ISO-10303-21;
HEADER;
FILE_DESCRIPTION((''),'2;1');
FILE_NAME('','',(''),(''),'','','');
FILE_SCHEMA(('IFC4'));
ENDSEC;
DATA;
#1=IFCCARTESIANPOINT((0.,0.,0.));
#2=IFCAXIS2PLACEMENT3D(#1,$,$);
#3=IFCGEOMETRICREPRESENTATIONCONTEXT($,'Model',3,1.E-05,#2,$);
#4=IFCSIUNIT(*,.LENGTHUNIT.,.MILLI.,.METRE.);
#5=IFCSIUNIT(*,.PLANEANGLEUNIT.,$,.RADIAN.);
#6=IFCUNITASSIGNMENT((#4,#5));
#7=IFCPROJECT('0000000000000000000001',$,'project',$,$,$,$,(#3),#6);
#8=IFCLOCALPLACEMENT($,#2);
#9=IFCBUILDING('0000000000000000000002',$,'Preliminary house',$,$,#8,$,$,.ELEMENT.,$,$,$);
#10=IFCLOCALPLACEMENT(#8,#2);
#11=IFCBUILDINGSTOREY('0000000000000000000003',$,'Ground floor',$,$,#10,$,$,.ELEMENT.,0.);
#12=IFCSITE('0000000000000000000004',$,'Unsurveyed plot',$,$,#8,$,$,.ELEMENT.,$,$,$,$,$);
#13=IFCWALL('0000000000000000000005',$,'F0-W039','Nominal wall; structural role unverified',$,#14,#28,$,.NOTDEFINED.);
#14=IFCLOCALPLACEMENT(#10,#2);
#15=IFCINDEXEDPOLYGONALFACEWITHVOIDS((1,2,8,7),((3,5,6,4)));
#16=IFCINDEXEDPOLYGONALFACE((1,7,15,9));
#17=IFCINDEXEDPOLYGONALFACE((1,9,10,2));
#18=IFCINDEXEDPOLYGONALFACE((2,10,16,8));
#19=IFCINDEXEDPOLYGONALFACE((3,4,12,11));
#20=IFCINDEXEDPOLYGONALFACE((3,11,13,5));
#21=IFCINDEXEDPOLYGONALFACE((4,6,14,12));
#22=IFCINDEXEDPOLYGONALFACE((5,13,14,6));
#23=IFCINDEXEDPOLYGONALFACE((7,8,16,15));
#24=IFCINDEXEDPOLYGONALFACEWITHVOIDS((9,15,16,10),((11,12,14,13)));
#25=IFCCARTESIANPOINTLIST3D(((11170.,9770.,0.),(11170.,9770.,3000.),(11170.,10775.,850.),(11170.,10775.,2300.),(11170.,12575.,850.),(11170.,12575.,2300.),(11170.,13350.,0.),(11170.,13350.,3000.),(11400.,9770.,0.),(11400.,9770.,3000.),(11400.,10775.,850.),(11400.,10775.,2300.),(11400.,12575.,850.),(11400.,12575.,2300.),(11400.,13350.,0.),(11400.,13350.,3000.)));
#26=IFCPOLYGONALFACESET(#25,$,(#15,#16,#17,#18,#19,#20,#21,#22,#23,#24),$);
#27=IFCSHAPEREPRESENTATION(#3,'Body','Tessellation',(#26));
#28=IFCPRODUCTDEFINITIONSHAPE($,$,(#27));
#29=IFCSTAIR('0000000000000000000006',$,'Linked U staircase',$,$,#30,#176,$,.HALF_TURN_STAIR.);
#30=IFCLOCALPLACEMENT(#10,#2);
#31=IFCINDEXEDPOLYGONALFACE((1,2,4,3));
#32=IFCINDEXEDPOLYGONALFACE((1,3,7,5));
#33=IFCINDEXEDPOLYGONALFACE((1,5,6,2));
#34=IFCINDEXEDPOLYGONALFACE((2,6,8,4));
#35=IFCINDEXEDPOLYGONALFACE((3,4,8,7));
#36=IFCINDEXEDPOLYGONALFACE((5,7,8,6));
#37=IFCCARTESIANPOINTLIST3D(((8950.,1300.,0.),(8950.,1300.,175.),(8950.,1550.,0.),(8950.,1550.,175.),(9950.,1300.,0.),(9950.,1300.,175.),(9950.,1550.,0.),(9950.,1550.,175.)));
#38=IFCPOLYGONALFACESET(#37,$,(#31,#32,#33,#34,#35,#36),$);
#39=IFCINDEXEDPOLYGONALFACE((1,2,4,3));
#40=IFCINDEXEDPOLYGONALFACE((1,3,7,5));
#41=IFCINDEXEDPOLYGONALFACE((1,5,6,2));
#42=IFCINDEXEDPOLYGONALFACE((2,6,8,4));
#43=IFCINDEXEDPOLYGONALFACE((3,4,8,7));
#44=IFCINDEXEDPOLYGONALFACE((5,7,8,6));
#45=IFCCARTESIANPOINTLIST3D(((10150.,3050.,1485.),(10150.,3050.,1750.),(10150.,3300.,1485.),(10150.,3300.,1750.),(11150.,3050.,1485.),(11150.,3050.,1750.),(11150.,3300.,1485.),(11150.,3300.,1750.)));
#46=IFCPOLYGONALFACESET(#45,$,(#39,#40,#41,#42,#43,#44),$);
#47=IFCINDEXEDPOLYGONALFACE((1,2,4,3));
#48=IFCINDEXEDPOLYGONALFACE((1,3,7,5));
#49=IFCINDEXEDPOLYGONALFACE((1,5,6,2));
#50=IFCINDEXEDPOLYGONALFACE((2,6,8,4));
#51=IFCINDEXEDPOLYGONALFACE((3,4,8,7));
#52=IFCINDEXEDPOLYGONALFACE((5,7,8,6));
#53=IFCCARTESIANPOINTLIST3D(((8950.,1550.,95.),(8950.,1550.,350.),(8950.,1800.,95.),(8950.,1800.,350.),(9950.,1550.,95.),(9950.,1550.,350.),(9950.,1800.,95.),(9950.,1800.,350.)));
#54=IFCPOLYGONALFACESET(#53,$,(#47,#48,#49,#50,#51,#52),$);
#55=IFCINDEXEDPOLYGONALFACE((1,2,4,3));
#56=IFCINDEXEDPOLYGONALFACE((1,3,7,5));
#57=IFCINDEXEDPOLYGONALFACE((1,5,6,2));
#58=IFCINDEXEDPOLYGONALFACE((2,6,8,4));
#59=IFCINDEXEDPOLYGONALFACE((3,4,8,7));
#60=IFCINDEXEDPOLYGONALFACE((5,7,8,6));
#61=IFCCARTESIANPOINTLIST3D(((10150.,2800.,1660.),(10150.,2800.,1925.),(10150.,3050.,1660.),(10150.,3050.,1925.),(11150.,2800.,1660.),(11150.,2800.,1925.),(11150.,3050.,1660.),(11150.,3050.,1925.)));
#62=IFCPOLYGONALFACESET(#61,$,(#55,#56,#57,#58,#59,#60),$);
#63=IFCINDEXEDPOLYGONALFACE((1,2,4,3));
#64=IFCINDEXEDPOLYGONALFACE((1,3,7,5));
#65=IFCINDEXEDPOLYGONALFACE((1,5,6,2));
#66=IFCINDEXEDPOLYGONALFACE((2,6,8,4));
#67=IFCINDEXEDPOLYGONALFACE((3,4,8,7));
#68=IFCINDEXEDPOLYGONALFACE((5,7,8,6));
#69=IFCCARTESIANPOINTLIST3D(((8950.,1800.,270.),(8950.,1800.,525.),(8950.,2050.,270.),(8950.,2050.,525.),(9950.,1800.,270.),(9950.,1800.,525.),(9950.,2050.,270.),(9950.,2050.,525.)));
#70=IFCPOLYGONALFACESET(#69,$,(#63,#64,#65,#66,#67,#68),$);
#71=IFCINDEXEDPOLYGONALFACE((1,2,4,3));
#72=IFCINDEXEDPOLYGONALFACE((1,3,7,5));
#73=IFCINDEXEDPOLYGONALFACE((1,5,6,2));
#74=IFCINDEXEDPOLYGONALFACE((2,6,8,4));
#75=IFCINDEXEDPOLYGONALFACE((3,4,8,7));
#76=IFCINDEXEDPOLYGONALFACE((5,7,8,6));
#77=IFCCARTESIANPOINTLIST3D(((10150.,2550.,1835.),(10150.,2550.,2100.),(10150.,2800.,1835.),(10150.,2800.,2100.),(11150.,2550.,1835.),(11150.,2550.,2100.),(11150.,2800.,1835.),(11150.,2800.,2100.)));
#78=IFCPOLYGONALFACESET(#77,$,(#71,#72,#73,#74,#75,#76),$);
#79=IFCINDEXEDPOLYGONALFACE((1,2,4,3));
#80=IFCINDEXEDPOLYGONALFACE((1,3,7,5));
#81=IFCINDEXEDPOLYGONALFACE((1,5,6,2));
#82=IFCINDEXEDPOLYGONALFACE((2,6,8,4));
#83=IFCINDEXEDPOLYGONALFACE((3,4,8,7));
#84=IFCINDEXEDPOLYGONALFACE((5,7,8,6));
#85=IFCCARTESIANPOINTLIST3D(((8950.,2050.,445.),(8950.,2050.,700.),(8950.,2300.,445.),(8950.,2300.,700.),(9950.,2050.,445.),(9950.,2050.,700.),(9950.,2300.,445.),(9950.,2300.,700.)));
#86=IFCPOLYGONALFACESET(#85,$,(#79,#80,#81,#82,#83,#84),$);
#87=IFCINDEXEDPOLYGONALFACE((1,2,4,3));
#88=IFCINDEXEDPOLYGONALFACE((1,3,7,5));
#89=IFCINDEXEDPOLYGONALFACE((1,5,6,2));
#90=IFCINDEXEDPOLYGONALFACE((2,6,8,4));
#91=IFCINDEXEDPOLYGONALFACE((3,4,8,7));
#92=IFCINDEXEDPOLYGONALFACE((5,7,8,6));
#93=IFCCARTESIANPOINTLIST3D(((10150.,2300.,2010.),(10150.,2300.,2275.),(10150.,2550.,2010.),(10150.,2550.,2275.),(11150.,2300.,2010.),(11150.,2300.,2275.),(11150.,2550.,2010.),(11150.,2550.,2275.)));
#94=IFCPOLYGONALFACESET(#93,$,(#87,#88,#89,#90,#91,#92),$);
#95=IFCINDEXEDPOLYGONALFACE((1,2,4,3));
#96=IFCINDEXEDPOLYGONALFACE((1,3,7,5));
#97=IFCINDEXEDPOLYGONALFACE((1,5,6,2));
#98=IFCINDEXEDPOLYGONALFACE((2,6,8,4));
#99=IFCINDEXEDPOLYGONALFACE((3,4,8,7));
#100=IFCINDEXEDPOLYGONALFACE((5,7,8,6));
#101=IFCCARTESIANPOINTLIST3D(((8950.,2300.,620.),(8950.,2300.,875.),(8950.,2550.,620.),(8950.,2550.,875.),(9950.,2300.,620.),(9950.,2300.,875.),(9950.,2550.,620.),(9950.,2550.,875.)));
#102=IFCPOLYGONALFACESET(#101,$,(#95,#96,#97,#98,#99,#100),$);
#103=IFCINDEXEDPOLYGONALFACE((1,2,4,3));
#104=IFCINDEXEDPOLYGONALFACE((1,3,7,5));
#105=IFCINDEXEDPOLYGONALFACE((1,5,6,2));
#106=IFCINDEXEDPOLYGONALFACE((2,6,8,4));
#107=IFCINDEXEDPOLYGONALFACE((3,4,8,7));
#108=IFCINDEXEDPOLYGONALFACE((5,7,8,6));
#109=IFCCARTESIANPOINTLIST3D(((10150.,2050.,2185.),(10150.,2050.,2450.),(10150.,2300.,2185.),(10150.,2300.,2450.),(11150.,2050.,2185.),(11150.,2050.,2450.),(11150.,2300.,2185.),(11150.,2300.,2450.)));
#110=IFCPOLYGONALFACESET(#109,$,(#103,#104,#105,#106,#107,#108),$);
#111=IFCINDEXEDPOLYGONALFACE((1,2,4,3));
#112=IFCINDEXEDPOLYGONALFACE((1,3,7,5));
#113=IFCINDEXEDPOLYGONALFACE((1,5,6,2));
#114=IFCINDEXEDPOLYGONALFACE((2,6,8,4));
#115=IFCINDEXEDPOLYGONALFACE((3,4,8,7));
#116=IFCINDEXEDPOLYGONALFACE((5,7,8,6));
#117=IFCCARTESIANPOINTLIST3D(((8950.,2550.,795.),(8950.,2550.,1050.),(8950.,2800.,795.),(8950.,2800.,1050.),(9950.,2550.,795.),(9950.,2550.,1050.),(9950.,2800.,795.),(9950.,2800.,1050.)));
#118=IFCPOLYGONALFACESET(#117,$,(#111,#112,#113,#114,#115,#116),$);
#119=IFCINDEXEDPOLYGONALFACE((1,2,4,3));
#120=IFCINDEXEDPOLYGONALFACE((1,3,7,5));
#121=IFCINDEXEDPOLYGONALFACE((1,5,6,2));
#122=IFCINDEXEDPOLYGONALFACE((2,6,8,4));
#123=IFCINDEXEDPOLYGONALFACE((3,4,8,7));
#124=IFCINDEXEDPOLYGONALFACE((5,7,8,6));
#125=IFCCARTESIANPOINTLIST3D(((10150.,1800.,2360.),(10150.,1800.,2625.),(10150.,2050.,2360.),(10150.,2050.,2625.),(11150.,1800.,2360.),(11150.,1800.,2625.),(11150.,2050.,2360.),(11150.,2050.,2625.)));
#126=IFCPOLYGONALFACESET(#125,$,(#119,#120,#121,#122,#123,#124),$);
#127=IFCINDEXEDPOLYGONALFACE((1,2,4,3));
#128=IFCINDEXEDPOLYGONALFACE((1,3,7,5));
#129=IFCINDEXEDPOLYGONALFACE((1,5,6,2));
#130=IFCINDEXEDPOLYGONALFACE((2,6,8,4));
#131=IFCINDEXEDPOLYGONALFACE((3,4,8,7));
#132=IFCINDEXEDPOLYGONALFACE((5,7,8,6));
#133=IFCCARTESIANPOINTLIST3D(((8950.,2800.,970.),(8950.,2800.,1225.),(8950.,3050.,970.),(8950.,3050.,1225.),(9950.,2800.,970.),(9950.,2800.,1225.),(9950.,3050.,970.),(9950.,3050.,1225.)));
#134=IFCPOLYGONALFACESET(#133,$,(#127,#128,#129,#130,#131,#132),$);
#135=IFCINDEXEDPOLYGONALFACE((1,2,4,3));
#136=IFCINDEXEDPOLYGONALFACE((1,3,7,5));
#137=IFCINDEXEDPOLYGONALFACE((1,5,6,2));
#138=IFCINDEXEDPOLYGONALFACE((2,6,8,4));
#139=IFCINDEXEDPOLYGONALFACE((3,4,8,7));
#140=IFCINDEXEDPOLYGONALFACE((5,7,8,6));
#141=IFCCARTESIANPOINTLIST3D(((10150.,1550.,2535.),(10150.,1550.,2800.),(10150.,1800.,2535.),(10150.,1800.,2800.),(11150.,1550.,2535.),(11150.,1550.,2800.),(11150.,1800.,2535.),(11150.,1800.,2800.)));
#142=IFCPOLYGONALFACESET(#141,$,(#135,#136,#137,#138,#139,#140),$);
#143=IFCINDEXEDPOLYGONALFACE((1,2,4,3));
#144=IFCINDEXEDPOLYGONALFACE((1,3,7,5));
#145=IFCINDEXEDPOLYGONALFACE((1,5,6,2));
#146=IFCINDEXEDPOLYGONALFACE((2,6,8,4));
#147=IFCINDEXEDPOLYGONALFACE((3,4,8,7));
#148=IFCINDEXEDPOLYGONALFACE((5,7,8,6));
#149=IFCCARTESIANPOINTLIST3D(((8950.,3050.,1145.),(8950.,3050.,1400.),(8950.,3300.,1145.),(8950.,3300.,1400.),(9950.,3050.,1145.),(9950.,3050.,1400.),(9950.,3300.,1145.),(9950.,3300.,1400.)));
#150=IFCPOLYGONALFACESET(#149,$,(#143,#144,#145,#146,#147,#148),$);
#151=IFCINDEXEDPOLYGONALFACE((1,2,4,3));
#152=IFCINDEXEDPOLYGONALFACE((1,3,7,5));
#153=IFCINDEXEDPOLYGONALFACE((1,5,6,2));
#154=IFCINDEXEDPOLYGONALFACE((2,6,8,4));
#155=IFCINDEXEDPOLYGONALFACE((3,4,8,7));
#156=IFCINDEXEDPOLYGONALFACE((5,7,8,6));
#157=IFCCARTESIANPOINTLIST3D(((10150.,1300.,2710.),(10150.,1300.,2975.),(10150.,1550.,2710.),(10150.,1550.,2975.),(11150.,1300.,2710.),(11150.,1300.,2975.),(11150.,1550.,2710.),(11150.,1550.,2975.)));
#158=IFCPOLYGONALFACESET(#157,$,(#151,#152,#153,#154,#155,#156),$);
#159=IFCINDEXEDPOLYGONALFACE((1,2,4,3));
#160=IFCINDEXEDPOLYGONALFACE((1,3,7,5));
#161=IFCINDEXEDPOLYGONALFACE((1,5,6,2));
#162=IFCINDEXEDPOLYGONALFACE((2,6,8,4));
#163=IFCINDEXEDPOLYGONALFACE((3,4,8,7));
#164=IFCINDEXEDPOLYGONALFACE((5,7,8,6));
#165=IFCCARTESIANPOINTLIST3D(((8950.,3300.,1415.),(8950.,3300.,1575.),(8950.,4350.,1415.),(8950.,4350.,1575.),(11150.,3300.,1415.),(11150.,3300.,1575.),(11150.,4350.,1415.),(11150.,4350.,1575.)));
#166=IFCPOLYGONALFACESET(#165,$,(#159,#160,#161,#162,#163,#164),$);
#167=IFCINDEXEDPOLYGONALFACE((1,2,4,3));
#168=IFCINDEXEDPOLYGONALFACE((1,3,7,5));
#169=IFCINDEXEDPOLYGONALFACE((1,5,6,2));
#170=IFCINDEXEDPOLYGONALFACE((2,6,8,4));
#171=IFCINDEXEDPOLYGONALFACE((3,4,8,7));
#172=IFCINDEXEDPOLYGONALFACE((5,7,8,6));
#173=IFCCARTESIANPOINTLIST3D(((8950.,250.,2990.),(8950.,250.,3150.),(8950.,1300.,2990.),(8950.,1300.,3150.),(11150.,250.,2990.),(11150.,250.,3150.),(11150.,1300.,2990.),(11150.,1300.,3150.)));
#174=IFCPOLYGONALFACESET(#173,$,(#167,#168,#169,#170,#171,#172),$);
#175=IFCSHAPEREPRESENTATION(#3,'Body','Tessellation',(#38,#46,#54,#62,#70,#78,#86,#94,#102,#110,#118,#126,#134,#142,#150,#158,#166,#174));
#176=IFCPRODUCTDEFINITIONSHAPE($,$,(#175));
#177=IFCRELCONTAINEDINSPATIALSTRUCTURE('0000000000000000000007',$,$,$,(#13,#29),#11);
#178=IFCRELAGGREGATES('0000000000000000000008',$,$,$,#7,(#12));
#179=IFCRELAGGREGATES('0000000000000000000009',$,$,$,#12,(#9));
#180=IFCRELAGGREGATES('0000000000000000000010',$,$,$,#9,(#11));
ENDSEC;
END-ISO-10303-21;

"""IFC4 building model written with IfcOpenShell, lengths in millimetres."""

from ifc_helpers import new_model, si_unit, frame, origin, place, context, project, spatial, polyline, outline, extrude, element, save


model = new_model("IFC4")

# Units and contexts
model_context = context("Model", 3, precision=1e-05, world=origin())
ifc_project = project(units=[si_unit("LENGTHUNIT", "METRE", prefix="MILLI"), si_unit("PLANEANGLEUNIT", "RADIAN")], contexts=[model_context])

# Site, building, storey
placement_1 = place(None, origin())
site = spatial("IfcSite", under=ifc_project, at=placement_1, Name="Unsurveyed plot", CompositionType="ELEMENT")
building = spatial("IfcBuilding", under=site, at=placement_1, Name="Preliminary house", CompositionType="ELEMENT")
placement_2 = place(placement_1, origin())
storey = spatial("IfcBuildingStorey", under=building, at=placement_2, Name="Ground floor", CompositionType="ELEMENT", Elevation=0.0)

# Wall, opening
wall_1 = element("IfcWall", 1, at=placement_2, inside=storey, Name="F0-W039", Description="Nominal wall; structural role unverified", PredefinedType="NOTDEFINED", context=model_context, shape_type="SweptSolid", body=[
    extrude(outline(polyline([(11170.0, 9770.0), (11170.0, 13350.0), (11400.0, 13350.0), (11400.0, 9770.0), (11170.0, 9770.0)])), origin(), (0.0, 0.0, 1.0), 3000.0),
])
element("IfcOpeningElement", 2, at=placement_2, cuts=wall_1, PredefinedType="OPENING", context=model_context, shape_type="SweptSolid", body=[
    extrude(outline(polyline([(11815.0, 10775.0), (11815.0, 12575.0), (10755.0, 12575.0), (10755.0, 10775.0), (11815.0, 10775.0)])), frame((0.0, 0.0, 850.0)), (0.0, 0.0, 1.0), 1450.0),
])

# Stair
element("IfcStair", 3, at=placement_2, inside=storey, Name="Linked U staircase", PredefinedType="HALF_TURN_STAIR", context=model_context, shape_type="SweptSolid", body=[
    extrude(outline(polyline([(9950.0, 1300.0), (9950.0, 1550.0), (8950.0, 1550.0), (8950.0, 1300.0), (9950.0, 1300.0)])), origin(), (0.0, 0.0, 1.0), 175.0),
    extrude(outline(polyline([(11150.0, 3050.0), (11150.0, 3300.0), (10150.0, 3300.0), (10150.0, 3050.0), (11150.0, 3050.0)])), frame((0.0, 0.0, 1485.0)), (0.0, 0.0, 1.0), 265.0),
    extrude(outline(polyline([(9950.0, 1550.0), (9950.0, 1800.0), (8950.0, 1800.0), (8950.0, 1550.0), (9950.0, 1550.0)])), frame((0.0, 0.0, 95.0)), (0.0, 0.0, 1.0), 255.0),
    extrude(outline(polyline([(11150.0, 2800.0), (11150.0, 3050.0), (10150.0, 3050.0), (10150.0, 2800.0), (11150.0, 2800.0)])), frame((0.0, 0.0, 1660.0)), (0.0, 0.0, 1.0), 265.0),
    extrude(outline(polyline([(9950.0, 1800.0), (9950.0, 2050.0), (8950.0, 2050.0), (8950.0, 1800.0), (9950.0, 1800.0)])), frame((0.0, 0.0, 270.0)), (0.0, 0.0, 1.0), 255.0),
    extrude(outline(polyline([(11150.0, 2550.0), (11150.0, 2800.0), (10150.0, 2800.0), (10150.0, 2550.0), (11150.0, 2550.0)])), frame((0.0, 0.0, 1835.0)), (0.0, 0.0, 1.0), 265.0),
    extrude(outline(polyline([(9950.0, 2050.0), (9950.0, 2300.0), (8950.0, 2300.0), (8950.0, 2050.0), (9950.0, 2050.0)])), frame((0.0, 0.0, 445.0)), (0.0, 0.0, 1.0), 255.0),
    extrude(outline(polyline([(11150.0, 2300.0), (11150.0, 2550.0), (10150.0, 2550.0), (10150.0, 2300.0), (11150.0, 2300.0)])), frame((0.0, 0.0, 2010.0)), (0.0, 0.0, 1.0), 265.0),
    extrude(outline(polyline([(9950.0, 2300.0), (9950.0, 2550.0), (8950.0, 2550.0), (8950.0, 2300.0), (9950.0, 2300.0)])), frame((0.0, 0.0, 620.0)), (0.0, 0.0, 1.0), 255.0),
    extrude(outline(polyline([(11150.0, 2050.0), (11150.0, 2300.0), (10150.0, 2300.0), (10150.0, 2050.0), (11150.0, 2050.0)])), frame((0.0, 0.0, 2185.0)), (0.0, 0.0, 1.0), 265.0),
    extrude(outline(polyline([(9950.0, 2550.0), (9950.0, 2800.0), (8950.0, 2800.0), (8950.0, 2550.0), (9950.0, 2550.0)])), frame((0.0, 0.0, 795.0)), (0.0, 0.0, 1.0), 255.0),
    extrude(outline(polyline([(11150.0, 1800.0), (11150.0, 2050.0), (10150.0, 2050.0), (10150.0, 1800.0), (11150.0, 1800.0)])), frame((0.0, 0.0, 2360.0)), (0.0, 0.0, 1.0), 265.0),
    extrude(outline(polyline([(9950.0, 2800.0), (9950.0, 3050.0), (8950.0, 3050.0), (8950.0, 2800.0), (9950.0, 2800.0)])), frame((0.0, 0.0, 970.0)), (0.0, 0.0, 1.0), 255.0),
    extrude(outline(polyline([(11150.0, 1550.0), (11150.0, 1800.0), (10150.0, 1800.0), (10150.0, 1550.0), (11150.0, 1550.0)])), frame((0.0, 0.0, 2535.0)), (0.0, 0.0, 1.0), 265.0),
    extrude(outline(polyline([(9950.0, 3050.0), (9950.0, 3300.0), (8950.0, 3300.0), (8950.0, 3050.0), (9950.0, 3050.0)])), frame((0.0, 0.0, 1145.0)), (0.0, 0.0, 1.0), 255.0),
    extrude(outline(polyline([(11150.0, 1300.0), (11150.0, 1550.0), (10150.0, 1550.0), (10150.0, 1300.0), (11150.0, 1300.0)])), frame((0.0, 0.0, 2710.0)), (0.0, 0.0, 1.0), 265.0),
    extrude(outline(polyline([(11150.0, 3300.0), (11150.0, 4350.0), (8950.0, 4350.0), (8950.0, 3300.0), (11150.0, 3300.0)])), frame((0.0, 0.0, 1415.0)), (0.0, 0.0, 1.0), 160.0),
    extrude(outline(polyline([(11150.0, 250.0), (11150.0, 1300.0), (8950.0, 1300.0), (8950.0, 250.0), (11150.0, 250.0)])), frame((0.0, 0.0, 2990.0)), (0.0, 0.0, 1.0), 160.0),
])

save(model, "model.ifc")
